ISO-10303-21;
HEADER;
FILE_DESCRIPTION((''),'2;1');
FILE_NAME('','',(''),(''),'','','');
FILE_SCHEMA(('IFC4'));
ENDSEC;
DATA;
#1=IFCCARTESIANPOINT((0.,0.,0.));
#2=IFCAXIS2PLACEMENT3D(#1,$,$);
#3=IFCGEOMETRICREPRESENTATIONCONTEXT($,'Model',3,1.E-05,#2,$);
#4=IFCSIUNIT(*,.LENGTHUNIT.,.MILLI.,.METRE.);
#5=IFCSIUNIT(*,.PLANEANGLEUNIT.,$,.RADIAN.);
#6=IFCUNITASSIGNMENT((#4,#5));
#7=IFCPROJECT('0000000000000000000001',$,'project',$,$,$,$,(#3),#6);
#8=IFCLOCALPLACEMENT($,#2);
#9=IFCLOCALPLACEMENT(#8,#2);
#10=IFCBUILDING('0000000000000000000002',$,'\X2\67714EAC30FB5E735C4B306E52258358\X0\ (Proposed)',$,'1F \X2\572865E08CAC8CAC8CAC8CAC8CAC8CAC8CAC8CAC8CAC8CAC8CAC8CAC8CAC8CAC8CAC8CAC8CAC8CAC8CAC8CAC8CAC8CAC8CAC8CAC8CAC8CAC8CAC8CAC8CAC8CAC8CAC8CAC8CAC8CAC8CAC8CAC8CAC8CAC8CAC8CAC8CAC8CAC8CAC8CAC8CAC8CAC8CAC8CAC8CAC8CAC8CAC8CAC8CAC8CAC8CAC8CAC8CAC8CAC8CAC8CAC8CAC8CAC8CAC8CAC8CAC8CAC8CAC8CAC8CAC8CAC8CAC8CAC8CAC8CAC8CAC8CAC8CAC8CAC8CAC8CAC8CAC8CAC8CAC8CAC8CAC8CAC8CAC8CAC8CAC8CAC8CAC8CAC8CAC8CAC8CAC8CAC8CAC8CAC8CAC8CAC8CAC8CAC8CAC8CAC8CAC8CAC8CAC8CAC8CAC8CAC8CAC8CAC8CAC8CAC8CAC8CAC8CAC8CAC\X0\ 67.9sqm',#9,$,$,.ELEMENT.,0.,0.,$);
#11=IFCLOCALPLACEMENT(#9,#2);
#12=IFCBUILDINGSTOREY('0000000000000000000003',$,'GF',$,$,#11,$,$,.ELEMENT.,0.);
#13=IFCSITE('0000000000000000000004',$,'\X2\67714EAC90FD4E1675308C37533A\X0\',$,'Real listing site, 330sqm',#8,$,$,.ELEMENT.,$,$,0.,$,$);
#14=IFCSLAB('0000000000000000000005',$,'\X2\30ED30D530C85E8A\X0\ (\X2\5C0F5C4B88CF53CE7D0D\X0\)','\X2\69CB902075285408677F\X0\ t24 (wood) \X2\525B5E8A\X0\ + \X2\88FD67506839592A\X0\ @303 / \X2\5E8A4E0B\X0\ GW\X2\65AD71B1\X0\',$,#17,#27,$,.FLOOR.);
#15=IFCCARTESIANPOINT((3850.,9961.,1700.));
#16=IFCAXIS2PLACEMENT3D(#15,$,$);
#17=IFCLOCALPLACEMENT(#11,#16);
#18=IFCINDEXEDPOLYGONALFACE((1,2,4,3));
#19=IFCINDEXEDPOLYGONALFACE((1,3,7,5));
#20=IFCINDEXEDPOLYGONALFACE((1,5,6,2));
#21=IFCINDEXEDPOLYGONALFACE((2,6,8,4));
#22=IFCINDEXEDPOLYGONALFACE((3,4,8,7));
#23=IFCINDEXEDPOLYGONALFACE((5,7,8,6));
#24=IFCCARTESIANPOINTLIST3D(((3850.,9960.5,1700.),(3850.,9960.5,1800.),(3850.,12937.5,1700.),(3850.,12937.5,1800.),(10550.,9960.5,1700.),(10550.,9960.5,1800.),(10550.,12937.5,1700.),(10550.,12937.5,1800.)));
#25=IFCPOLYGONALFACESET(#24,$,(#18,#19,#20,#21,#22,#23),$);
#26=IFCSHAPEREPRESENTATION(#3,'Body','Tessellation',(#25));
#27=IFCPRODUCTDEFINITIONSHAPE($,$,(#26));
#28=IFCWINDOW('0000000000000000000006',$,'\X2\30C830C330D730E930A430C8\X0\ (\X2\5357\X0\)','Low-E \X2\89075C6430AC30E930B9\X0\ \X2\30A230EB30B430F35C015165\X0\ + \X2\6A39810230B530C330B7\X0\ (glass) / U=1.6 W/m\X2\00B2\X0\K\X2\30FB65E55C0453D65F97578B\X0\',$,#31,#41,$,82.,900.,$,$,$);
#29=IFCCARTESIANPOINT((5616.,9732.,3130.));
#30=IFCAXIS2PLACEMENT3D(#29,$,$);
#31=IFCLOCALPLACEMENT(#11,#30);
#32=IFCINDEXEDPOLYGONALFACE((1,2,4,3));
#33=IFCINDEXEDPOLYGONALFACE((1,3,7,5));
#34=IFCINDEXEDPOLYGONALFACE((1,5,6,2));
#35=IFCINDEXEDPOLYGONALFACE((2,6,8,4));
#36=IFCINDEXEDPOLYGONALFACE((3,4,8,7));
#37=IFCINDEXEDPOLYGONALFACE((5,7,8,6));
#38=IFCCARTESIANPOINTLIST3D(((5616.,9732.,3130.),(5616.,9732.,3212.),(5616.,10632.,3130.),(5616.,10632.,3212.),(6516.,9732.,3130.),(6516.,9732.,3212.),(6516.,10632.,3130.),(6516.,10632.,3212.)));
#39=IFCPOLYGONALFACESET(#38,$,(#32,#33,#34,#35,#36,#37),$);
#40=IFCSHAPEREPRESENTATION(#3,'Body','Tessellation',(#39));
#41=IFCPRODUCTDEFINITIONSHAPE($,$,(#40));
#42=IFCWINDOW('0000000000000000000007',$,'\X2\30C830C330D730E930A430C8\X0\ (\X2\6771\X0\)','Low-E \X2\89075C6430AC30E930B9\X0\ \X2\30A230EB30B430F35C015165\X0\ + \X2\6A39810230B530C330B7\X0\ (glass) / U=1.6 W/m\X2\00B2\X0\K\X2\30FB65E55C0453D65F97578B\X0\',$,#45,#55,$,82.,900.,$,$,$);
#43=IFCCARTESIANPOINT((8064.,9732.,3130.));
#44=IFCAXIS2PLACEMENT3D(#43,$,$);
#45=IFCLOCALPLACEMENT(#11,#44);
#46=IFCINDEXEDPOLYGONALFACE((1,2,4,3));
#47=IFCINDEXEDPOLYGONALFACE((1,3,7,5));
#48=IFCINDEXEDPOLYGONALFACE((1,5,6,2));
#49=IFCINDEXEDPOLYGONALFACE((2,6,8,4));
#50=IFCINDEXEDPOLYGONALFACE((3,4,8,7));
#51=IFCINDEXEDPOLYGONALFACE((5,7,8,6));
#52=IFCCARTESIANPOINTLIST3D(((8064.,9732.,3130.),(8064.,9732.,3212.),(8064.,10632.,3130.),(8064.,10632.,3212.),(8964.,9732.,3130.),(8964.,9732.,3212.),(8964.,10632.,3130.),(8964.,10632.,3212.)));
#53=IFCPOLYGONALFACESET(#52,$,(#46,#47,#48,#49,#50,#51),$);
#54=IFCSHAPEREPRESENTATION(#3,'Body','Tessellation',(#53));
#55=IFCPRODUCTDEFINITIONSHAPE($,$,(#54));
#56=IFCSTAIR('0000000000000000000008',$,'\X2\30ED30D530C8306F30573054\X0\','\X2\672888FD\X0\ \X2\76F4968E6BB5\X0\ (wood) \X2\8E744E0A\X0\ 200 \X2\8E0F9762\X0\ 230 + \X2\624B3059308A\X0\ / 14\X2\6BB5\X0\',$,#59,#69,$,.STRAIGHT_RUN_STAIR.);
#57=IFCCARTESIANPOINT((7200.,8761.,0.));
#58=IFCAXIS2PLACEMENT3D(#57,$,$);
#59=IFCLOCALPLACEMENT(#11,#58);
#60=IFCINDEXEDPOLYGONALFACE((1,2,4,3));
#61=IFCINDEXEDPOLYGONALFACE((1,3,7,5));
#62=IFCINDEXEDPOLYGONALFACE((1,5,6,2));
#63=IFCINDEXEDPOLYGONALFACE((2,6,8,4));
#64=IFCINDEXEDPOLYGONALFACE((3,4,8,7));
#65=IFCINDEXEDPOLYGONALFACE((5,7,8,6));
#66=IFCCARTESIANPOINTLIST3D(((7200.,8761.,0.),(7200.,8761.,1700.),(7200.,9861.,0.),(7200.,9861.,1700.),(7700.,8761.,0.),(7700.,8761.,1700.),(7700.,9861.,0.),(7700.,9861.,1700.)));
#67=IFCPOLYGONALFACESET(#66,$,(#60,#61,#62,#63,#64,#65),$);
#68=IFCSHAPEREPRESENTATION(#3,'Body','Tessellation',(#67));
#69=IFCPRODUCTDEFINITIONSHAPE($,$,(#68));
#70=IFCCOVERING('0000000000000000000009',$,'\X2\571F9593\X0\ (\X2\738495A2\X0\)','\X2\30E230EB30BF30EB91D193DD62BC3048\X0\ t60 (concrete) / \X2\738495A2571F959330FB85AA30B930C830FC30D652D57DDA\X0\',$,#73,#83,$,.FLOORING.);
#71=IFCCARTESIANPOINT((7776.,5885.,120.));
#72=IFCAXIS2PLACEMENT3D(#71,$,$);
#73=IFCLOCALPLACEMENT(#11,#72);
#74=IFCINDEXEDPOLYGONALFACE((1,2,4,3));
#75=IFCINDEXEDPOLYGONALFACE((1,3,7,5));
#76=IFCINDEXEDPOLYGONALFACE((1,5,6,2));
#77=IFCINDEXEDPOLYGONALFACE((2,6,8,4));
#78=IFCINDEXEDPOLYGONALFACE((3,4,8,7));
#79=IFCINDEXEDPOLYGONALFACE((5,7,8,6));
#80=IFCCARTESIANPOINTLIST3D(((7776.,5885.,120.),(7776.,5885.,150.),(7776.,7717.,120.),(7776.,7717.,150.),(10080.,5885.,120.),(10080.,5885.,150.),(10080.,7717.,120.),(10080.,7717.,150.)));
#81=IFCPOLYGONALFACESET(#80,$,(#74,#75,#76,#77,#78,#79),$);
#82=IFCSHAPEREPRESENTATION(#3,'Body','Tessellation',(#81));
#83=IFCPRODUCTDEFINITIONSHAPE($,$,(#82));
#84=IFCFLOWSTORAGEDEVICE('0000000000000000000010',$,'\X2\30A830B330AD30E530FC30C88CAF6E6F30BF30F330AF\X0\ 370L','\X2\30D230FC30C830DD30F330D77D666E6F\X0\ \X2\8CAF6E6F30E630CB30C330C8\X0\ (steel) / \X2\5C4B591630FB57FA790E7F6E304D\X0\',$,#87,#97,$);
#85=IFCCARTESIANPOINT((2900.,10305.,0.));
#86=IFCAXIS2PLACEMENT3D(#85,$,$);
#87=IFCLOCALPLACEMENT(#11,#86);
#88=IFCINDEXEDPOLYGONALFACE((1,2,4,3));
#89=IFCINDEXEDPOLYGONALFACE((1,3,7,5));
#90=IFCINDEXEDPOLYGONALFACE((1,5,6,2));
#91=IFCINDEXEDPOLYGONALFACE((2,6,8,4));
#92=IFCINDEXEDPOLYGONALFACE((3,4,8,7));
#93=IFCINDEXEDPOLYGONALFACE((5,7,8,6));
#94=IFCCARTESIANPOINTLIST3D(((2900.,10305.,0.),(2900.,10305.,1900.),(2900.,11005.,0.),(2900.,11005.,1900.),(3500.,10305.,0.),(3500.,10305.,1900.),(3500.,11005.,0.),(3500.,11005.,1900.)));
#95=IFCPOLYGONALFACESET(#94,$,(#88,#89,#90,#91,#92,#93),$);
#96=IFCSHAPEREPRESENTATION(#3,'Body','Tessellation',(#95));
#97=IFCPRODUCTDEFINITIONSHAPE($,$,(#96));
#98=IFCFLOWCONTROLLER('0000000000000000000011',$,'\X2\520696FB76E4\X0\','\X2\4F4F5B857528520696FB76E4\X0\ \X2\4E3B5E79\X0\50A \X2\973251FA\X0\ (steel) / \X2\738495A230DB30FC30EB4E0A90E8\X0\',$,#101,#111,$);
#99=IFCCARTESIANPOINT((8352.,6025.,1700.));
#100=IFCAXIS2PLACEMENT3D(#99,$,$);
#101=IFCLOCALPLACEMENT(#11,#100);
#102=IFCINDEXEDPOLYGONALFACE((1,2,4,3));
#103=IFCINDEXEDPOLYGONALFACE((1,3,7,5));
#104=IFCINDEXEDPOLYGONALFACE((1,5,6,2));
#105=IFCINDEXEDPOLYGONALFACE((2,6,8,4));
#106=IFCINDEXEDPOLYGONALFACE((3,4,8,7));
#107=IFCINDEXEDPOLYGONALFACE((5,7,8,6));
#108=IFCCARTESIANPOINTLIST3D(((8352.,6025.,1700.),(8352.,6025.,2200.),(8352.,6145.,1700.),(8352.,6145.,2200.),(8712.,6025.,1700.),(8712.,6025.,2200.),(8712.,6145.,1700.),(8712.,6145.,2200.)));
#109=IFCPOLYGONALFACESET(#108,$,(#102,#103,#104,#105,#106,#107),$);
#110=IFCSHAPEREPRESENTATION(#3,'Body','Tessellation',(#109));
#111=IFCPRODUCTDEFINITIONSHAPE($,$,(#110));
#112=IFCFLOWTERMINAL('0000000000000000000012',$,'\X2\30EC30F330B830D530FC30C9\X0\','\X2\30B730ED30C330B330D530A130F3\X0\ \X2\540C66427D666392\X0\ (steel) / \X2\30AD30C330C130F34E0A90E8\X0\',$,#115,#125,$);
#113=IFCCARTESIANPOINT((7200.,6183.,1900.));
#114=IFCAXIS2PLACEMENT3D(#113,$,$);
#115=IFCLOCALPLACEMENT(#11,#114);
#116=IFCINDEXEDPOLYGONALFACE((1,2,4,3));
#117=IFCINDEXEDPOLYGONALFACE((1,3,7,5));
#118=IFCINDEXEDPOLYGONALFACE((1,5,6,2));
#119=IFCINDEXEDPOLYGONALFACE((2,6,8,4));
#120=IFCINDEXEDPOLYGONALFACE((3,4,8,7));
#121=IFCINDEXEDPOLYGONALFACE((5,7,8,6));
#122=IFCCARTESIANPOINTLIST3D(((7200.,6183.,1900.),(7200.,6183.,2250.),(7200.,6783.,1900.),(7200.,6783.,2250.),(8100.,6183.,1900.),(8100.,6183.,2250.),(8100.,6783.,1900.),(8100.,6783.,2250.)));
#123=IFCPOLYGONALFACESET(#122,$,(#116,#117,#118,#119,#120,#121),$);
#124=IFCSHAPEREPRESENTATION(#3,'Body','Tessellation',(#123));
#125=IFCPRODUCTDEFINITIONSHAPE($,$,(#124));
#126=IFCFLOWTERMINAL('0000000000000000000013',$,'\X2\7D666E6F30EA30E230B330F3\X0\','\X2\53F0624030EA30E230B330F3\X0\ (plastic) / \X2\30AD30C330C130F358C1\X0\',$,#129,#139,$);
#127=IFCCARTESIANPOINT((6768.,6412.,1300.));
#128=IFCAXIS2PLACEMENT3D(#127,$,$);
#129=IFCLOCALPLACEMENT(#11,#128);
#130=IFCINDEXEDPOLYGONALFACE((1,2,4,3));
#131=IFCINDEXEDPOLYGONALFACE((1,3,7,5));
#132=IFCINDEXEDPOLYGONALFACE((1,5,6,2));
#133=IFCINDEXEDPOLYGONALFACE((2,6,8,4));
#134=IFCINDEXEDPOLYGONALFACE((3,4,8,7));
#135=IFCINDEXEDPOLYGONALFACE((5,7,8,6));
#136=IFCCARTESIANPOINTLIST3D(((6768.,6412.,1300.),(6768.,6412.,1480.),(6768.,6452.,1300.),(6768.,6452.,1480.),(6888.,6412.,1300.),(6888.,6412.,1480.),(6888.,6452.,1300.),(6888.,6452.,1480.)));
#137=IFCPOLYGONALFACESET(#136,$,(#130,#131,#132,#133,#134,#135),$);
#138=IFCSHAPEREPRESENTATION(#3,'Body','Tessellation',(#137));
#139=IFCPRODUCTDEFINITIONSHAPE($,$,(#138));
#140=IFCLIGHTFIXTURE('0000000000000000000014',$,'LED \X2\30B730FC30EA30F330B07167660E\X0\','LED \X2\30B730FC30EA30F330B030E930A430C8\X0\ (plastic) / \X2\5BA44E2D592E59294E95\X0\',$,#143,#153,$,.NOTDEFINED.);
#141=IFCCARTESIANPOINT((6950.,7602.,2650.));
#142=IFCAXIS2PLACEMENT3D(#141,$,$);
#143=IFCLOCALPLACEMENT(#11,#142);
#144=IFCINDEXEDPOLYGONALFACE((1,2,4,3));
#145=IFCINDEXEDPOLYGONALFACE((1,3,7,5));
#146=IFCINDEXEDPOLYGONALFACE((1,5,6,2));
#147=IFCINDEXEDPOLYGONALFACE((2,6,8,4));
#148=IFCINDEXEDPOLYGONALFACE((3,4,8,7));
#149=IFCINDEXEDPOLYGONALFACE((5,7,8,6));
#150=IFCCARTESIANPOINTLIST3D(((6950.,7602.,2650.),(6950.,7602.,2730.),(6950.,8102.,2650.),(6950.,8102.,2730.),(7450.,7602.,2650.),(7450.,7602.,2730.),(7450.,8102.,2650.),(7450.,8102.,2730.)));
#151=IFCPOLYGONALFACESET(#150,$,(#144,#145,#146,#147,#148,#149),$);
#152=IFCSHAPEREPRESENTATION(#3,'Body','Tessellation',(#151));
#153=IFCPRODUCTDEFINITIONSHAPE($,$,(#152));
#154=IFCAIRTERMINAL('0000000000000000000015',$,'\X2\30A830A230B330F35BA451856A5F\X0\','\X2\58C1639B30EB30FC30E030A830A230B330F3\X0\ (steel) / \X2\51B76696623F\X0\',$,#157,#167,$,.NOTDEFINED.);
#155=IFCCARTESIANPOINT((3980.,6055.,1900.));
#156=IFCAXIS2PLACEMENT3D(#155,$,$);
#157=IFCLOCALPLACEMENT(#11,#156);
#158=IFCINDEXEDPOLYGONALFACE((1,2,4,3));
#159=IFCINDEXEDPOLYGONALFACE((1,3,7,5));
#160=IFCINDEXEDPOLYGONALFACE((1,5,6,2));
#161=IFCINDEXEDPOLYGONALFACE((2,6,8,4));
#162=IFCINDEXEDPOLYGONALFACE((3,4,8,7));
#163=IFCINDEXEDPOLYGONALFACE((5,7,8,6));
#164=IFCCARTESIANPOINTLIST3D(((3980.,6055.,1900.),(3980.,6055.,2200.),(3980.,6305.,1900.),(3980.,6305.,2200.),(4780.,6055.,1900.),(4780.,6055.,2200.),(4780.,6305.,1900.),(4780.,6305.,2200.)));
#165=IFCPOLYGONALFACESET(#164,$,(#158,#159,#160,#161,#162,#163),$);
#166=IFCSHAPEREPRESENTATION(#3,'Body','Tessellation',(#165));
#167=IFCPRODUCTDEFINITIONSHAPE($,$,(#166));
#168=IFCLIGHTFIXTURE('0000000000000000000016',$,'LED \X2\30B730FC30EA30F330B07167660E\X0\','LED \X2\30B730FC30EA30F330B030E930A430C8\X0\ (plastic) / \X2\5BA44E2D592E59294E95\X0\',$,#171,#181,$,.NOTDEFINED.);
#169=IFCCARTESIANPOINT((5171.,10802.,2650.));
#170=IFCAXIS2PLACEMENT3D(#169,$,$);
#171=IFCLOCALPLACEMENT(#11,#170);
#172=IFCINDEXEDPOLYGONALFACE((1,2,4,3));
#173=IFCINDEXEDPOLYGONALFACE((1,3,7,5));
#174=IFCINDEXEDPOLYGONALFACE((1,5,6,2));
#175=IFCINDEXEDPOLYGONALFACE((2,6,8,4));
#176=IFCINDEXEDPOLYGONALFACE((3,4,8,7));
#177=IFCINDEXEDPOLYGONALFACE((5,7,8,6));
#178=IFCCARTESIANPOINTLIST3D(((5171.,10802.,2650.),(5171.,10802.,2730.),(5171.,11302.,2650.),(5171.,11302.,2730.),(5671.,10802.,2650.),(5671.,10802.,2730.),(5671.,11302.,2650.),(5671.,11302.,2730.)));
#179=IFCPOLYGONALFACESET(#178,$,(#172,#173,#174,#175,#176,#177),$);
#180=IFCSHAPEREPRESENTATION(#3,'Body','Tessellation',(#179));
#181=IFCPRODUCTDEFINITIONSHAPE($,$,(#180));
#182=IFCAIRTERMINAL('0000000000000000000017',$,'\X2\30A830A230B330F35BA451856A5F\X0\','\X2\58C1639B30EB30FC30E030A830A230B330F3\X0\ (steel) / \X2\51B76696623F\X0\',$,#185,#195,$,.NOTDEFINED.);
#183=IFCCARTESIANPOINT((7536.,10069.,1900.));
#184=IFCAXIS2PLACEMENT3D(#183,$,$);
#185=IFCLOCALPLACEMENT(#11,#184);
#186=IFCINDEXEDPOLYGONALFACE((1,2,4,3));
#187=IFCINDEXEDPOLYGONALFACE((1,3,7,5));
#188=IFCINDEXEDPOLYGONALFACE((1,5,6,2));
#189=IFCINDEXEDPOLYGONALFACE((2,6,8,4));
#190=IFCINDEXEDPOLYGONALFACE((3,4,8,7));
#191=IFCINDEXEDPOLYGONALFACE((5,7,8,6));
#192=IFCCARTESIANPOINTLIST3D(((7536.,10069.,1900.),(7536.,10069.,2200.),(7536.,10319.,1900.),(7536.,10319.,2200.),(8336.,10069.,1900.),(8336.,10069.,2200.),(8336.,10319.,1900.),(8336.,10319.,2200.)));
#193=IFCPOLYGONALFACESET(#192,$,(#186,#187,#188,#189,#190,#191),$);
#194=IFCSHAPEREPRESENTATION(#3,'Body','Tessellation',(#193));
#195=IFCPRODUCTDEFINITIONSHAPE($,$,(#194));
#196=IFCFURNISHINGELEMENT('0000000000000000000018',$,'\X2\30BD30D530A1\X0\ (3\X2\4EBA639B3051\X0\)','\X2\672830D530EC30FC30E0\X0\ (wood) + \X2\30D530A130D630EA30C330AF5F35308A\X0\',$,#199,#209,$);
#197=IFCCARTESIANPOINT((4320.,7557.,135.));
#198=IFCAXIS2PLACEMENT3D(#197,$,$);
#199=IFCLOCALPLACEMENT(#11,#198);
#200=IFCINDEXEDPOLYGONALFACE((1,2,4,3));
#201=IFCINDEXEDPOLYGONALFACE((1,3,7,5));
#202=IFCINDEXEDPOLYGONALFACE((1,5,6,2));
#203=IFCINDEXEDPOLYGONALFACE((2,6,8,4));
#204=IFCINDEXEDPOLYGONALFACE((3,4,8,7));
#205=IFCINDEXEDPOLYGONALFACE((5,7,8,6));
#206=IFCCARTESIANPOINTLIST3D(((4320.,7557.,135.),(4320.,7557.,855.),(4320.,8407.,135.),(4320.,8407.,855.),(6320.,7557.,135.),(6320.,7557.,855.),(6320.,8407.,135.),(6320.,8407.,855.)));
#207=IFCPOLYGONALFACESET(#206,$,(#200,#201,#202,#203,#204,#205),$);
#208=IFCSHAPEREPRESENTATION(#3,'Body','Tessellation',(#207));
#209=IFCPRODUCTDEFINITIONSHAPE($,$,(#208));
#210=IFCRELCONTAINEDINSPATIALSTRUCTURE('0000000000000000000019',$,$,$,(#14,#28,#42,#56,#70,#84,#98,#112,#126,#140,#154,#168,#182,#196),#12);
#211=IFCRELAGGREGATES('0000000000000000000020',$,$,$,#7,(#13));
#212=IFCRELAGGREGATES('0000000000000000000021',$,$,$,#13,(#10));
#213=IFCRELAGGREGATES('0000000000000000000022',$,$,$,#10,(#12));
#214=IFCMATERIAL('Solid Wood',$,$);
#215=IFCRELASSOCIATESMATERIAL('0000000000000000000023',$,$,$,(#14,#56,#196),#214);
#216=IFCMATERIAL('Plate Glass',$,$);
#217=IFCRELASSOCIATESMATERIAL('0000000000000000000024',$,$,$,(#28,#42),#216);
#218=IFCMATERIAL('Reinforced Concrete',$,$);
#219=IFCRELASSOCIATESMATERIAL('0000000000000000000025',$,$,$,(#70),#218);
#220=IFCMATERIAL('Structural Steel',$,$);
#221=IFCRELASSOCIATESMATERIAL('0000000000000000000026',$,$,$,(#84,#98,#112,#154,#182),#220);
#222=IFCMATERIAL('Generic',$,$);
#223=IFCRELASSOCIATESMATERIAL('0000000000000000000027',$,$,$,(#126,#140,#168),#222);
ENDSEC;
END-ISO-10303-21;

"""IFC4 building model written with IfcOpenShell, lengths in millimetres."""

from ifc_helpers import new_model, si_unit, frame, frame_2d, origin, place, context, project, spatial, rectangle, extrude, material, element, save


model = new_model("IFC4")

# Units and contexts
model_context = context("Model", 3, precision=1e-05, world=origin())
ifc_project = project(units=[si_unit("LENGTHUNIT", "METRE", prefix="MILLI"), si_unit("PLANEANGLEUNIT", "RADIAN")], contexts=[model_context])

# Site, building, storey
site_placement = place(None, origin())
site = spatial("IfcSite", under=ifc_project, at=site_placement, Name="東京都世田谷区", ObjectType="Real listing site, 330sqm", CompositionType="ELEMENT", RefElevation=0.0)
building_placement = place(site_placement, origin())
building = spatial("IfcBuilding", under=site, at=building_placement, Name="東京・平屋の別荘 (Proposed)", ObjectType="1F 在无責責責責責責責責責責責責責責責責責責責責責責責責責責責責責責責責責責責責責責責責責責責責責責責責責責責責責責責責責責責責責責責責責責責責責責責責責責責責責責責責責責責責責責責責責責責責責責責責責責責責責責責責責責責責責責責責責責責責責責 67.9sqm", CompositionType="ELEMENT", ElevationOfRefHeight=0.0, ElevationOfTerrain=0.0)
storey_placement = place(building_placement, origin())
storey = spatial("IfcBuildingStorey", under=building, at=storey_placement, Name="GF", CompositionType="ELEMENT", Elevation=0.0)

# Shared definitions
ifc_material_1 = material(Name="Solid Wood")

# Slab
slab_placement = place(storey_placement, frame((3850.0, 9961.0, 1700.0)))
element("IfcSlab", 1, at=slab_placement, inside=storey, material=ifc_material_1, Name="ロフト床 (小屋裏収納)", Description="構造用合板 t24 (wood) 剛床 + 製材根太 @303 / 床下 GW断熱", PredefinedType="FLOOR", context=model_context, shape_type="SweptSolid", body=[
    extrude(rectangle(XDim=6700.0, YDim=2977.0, at=frame_2d((3350.0, 1488.0))), frame((3850.0, 9961.0, 1700.0)), (0.0, 0.0, 1.0), 100.0),
])

# Windows
ifc_material_2 = material(Name="Plate Glass")
window_1_placement = place(storey_placement, frame((5616.0, 9732.0, 3130.0)))
element("IfcWindow", 2, at=window_1_placement, inside=storey, material=ifc_material_2, Name="トップライト (南)", Description="Low-E 複層ガラス アルゴン封入 + 樹脂サッシ (glass) / U=1.6 W/m²K・日射取得型", OverallHeight=82.0, OverallWidth=900.0, context=model_context, shape_type="SweptSolid", body=[
    extrude(rectangle(XDim=900.0, YDim=900.0, at=frame_2d((450.0, 450.0))), frame((5616.0, 9732.0, 3130.0)), (0.0, 0.0, 1.0), 82.0),
])
window_2_placement = place(storey_placement, frame((8064.0, 9732.0, 3130.0)))
element("IfcWindow", 3, at=window_2_placement, inside=storey, material=ifc_material_2, Name="トップライト (東)", Description="Low-E 複層ガラス アルゴン封入 + 樹脂サッシ (glass) / U=1.6 W/m²K・日射取得型", OverallHeight=82.0, OverallWidth=900.0, context=model_context, shape_type="SweptSolid", body=[
    extrude(rectangle(XDim=900.0, YDim=900.0, at=frame_2d((450.0, 450.0))), frame((8064.0, 9732.0, 3130.0)), (0.0, 0.0, 1.0), 82.0),
])

# Stair
stair_placement = place(storey_placement, frame((7200.0, 8761.0, 0.0)))
element("IfcStair", 4, at=stair_placement, inside=storey, material=ifc_material_1, Name="ロフトはしご", Description="木製 直階段 (wood) 蹴上 200 踏面 230 + 手すり / 14段", PredefinedType="STRAIGHT_RUN_STAIR", context=model_context, shape_type="SweptSolid", body=[
    extrude(rectangle(XDim=500.0, YDim=1100.0, at=frame_2d((250.0, 550.0))), frame((7200.0, 8761.0, 0.0)), (0.0, 0.0, 1.0), 1700.0),
])

# Covering
ifc_material_3 = material(Name="Reinforced Concrete")
covering_placement = place(storey_placement, frame((7776.0, 5885.0, 120.0)))
element("IfcCovering", 5, at=covering_placement, inside=storey, material=ifc_material_3, Name="土間 (玄関)", Description="モルタル金鏝押え t60 (concrete) / 玄関土間・薪ストーブ動線", PredefinedType="FLOORING", context=model_context, shape_type="SweptSolid", body=[
    extrude(rectangle(XDim=2304.0, YDim=1832.0, at=frame_2d((1152.0, 916.0))), frame((7776.0, 5885.0, 120.0)), (0.0, 0.0, 1.0), 30.0),
])

# Flow storage device
ifc_material_4 = material(Name="Structural Steel")
flow_storage_device_placement = place(storey_placement, frame((2900.0, 10305.0, 0.0)))
element("IfcFlowStorageDevice", 6, at=flow_storage_device_placement, inside=storey, material=ifc_material_4, Name="エコキュート貯湯タンク 370L", Description="ヒートポンプ給湯 貯湯ユニット (steel) / 屋外・基礎置き", context=model_context, shape_type="SweptSolid", body=[
    extrude(rectangle(XDim=600.0, YDim=700.0, at=frame_2d((300.0, 350.0))), frame((2900.0, 10305.0, 0.0)), (0.0, 0.0, 1.0), 1900.0),
])

# Flow controller
flow_controller_placement = place(storey_placement, frame((8352.0, 6025.0, 1700.0)))
element("IfcFlowController", 7, at=flow_controller_placement, inside=storey, material=ifc_material_4, Name="分電盤", Description="住宅用分電盤 主幹50A 露出 (steel) / 玄関ホール上部", context=model_context, shape_type="SweptSolid", body=[
    extrude(rectangle(XDim=360.0, YDim=120.0, at=frame_2d((180.0, 60.0))), frame((8352.0, 6025.0, 1700.0)), (0.0, 0.0, 1.0), 500.0),
])

# Flow terminals
flow_terminal_1_placement = place(storey_placement, frame((7200.0, 6183.0, 1900.0)))
element("IfcFlowTerminal", 8, at=flow_terminal_1_placement, inside=storey, material=ifc_material_4, Name="レンジフード", Description="シロッコファン 同時給排 (steel) / キッチン上部", context=model_context, shape_type="SweptSolid", body=[
    extrude(rectangle(XDim=900.0, YDim=600.0, at=frame_2d((450.0, 300.0))), frame((7200.0, 6183.0, 1900.0)), (0.0, 0.0, 1.0), 350.0),
])
ifc_material_5 = material(Name="Generic")
flow_terminal_2_placement = place(storey_placement, frame((6768.0, 6412.0, 1300.0)))
element("IfcFlowTerminal", 9, at=flow_terminal_2_placement, inside=storey, material=ifc_material_5, Name="給湯リモコン", Description="台所リモコン (plastic) / キッチン壁", context=model_context, shape_type="SweptSolid", body=[
    extrude(rectangle(XDim=120.0, YDim=40.0, at=frame_2d((60.0, 20.0))), frame((6768.0, 6412.0, 1300.0)), (0.0, 0.0, 1.0), 180.0),
])

# Light fixture
light_fixture_1_placement = place(storey_placement, frame((6950.0, 7602.0, 2650.0)))
element("IfcLightFixture", 10, at=light_fixture_1_placement, inside=storey, material=ifc_material_5, Name="LED シーリング照明", Description="LED シーリングライト (plastic) / 室中央天井", PredefinedType="NOTDEFINED", context=model_context, shape_type="SweptSolid", body=[
    extrude(rectangle(XDim=500.0, YDim=500.0, at=frame_2d((250.0, 250.0))), frame((6950.0, 7602.0, 2650.0)), (0.0, 0.0, 1.0), 80.0),
])

# Air terminal
air_terminal_1_placement = place(storey_placement, frame((3980.0, 6055.0, 1900.0)))
element("IfcAirTerminal", 11, at=air_terminal_1_placement, inside=storey, material=ifc_material_4, Name="エアコン室内機", Description="壁掛ルームエアコン (steel) / 冷暖房", PredefinedType="NOTDEFINED", context=model_context, shape_type="SweptSolid", body=[
    extrude(rectangle(XDim=800.0, YDim=250.0, at=frame_2d((400.0, 125.0))), frame((3980.0, 6055.0, 1900.0)), (0.0, 0.0, 1.0), 300.0),
])

# Light fixture
light_fixture_2_placement = place(storey_placement, frame((5171.0, 10802.0, 2650.0)))
element("IfcLightFixture", 12, at=light_fixture_2_placement, inside=storey, material=ifc_material_5, Name="LED シーリング照明", Description="LED シーリングライト (plastic) / 室中央天井", PredefinedType="NOTDEFINED", context=model_context, shape_type="SweptSolid", body=[
    extrude(rectangle(XDim=500.0, YDim=500.0, at=frame_2d((250.0, 250.0))), frame((5171.0, 10802.0, 2650.0)), (0.0, 0.0, 1.0), 80.0),
])

# Air terminal
air_terminal_2_placement = place(storey_placement, frame((7536.0, 10069.0, 1900.0)))
element("IfcAirTerminal", 13, at=air_terminal_2_placement, inside=storey, material=ifc_material_4, Name="エアコン室内機", Description="壁掛ルームエアコン (steel) / 冷暖房", PredefinedType="NOTDEFINED", context=model_context, shape_type="SweptSolid", body=[
    extrude(rectangle(XDim=800.0, YDim=250.0, at=frame_2d((400.0, 125.0))), frame((7536.0, 10069.0, 1900.0)), (0.0, 0.0, 1.0), 300.0),
])

# Furnishing element
furnishing_1_placement = place(storey_placement, frame((4320.0, 7557.0, 135.0)))
element("IfcFurnishingElement", 14, at=furnishing_1_placement, inside=storey, material=ifc_material_1, Name="ソファ (3人掛け)", Description="木フレーム (wood) + ファブリック張り", context=model_context, shape_type="SweptSolid", body=[
    extrude(rectangle(XDim=2000.0, YDim=850.0, at=frame_2d((1000.0, 425.0))), frame((4320.0, 7557.0, 135.0)), (0.0, 0.0, 1.0), 720.0),
])

save(model, "model.ifc")
